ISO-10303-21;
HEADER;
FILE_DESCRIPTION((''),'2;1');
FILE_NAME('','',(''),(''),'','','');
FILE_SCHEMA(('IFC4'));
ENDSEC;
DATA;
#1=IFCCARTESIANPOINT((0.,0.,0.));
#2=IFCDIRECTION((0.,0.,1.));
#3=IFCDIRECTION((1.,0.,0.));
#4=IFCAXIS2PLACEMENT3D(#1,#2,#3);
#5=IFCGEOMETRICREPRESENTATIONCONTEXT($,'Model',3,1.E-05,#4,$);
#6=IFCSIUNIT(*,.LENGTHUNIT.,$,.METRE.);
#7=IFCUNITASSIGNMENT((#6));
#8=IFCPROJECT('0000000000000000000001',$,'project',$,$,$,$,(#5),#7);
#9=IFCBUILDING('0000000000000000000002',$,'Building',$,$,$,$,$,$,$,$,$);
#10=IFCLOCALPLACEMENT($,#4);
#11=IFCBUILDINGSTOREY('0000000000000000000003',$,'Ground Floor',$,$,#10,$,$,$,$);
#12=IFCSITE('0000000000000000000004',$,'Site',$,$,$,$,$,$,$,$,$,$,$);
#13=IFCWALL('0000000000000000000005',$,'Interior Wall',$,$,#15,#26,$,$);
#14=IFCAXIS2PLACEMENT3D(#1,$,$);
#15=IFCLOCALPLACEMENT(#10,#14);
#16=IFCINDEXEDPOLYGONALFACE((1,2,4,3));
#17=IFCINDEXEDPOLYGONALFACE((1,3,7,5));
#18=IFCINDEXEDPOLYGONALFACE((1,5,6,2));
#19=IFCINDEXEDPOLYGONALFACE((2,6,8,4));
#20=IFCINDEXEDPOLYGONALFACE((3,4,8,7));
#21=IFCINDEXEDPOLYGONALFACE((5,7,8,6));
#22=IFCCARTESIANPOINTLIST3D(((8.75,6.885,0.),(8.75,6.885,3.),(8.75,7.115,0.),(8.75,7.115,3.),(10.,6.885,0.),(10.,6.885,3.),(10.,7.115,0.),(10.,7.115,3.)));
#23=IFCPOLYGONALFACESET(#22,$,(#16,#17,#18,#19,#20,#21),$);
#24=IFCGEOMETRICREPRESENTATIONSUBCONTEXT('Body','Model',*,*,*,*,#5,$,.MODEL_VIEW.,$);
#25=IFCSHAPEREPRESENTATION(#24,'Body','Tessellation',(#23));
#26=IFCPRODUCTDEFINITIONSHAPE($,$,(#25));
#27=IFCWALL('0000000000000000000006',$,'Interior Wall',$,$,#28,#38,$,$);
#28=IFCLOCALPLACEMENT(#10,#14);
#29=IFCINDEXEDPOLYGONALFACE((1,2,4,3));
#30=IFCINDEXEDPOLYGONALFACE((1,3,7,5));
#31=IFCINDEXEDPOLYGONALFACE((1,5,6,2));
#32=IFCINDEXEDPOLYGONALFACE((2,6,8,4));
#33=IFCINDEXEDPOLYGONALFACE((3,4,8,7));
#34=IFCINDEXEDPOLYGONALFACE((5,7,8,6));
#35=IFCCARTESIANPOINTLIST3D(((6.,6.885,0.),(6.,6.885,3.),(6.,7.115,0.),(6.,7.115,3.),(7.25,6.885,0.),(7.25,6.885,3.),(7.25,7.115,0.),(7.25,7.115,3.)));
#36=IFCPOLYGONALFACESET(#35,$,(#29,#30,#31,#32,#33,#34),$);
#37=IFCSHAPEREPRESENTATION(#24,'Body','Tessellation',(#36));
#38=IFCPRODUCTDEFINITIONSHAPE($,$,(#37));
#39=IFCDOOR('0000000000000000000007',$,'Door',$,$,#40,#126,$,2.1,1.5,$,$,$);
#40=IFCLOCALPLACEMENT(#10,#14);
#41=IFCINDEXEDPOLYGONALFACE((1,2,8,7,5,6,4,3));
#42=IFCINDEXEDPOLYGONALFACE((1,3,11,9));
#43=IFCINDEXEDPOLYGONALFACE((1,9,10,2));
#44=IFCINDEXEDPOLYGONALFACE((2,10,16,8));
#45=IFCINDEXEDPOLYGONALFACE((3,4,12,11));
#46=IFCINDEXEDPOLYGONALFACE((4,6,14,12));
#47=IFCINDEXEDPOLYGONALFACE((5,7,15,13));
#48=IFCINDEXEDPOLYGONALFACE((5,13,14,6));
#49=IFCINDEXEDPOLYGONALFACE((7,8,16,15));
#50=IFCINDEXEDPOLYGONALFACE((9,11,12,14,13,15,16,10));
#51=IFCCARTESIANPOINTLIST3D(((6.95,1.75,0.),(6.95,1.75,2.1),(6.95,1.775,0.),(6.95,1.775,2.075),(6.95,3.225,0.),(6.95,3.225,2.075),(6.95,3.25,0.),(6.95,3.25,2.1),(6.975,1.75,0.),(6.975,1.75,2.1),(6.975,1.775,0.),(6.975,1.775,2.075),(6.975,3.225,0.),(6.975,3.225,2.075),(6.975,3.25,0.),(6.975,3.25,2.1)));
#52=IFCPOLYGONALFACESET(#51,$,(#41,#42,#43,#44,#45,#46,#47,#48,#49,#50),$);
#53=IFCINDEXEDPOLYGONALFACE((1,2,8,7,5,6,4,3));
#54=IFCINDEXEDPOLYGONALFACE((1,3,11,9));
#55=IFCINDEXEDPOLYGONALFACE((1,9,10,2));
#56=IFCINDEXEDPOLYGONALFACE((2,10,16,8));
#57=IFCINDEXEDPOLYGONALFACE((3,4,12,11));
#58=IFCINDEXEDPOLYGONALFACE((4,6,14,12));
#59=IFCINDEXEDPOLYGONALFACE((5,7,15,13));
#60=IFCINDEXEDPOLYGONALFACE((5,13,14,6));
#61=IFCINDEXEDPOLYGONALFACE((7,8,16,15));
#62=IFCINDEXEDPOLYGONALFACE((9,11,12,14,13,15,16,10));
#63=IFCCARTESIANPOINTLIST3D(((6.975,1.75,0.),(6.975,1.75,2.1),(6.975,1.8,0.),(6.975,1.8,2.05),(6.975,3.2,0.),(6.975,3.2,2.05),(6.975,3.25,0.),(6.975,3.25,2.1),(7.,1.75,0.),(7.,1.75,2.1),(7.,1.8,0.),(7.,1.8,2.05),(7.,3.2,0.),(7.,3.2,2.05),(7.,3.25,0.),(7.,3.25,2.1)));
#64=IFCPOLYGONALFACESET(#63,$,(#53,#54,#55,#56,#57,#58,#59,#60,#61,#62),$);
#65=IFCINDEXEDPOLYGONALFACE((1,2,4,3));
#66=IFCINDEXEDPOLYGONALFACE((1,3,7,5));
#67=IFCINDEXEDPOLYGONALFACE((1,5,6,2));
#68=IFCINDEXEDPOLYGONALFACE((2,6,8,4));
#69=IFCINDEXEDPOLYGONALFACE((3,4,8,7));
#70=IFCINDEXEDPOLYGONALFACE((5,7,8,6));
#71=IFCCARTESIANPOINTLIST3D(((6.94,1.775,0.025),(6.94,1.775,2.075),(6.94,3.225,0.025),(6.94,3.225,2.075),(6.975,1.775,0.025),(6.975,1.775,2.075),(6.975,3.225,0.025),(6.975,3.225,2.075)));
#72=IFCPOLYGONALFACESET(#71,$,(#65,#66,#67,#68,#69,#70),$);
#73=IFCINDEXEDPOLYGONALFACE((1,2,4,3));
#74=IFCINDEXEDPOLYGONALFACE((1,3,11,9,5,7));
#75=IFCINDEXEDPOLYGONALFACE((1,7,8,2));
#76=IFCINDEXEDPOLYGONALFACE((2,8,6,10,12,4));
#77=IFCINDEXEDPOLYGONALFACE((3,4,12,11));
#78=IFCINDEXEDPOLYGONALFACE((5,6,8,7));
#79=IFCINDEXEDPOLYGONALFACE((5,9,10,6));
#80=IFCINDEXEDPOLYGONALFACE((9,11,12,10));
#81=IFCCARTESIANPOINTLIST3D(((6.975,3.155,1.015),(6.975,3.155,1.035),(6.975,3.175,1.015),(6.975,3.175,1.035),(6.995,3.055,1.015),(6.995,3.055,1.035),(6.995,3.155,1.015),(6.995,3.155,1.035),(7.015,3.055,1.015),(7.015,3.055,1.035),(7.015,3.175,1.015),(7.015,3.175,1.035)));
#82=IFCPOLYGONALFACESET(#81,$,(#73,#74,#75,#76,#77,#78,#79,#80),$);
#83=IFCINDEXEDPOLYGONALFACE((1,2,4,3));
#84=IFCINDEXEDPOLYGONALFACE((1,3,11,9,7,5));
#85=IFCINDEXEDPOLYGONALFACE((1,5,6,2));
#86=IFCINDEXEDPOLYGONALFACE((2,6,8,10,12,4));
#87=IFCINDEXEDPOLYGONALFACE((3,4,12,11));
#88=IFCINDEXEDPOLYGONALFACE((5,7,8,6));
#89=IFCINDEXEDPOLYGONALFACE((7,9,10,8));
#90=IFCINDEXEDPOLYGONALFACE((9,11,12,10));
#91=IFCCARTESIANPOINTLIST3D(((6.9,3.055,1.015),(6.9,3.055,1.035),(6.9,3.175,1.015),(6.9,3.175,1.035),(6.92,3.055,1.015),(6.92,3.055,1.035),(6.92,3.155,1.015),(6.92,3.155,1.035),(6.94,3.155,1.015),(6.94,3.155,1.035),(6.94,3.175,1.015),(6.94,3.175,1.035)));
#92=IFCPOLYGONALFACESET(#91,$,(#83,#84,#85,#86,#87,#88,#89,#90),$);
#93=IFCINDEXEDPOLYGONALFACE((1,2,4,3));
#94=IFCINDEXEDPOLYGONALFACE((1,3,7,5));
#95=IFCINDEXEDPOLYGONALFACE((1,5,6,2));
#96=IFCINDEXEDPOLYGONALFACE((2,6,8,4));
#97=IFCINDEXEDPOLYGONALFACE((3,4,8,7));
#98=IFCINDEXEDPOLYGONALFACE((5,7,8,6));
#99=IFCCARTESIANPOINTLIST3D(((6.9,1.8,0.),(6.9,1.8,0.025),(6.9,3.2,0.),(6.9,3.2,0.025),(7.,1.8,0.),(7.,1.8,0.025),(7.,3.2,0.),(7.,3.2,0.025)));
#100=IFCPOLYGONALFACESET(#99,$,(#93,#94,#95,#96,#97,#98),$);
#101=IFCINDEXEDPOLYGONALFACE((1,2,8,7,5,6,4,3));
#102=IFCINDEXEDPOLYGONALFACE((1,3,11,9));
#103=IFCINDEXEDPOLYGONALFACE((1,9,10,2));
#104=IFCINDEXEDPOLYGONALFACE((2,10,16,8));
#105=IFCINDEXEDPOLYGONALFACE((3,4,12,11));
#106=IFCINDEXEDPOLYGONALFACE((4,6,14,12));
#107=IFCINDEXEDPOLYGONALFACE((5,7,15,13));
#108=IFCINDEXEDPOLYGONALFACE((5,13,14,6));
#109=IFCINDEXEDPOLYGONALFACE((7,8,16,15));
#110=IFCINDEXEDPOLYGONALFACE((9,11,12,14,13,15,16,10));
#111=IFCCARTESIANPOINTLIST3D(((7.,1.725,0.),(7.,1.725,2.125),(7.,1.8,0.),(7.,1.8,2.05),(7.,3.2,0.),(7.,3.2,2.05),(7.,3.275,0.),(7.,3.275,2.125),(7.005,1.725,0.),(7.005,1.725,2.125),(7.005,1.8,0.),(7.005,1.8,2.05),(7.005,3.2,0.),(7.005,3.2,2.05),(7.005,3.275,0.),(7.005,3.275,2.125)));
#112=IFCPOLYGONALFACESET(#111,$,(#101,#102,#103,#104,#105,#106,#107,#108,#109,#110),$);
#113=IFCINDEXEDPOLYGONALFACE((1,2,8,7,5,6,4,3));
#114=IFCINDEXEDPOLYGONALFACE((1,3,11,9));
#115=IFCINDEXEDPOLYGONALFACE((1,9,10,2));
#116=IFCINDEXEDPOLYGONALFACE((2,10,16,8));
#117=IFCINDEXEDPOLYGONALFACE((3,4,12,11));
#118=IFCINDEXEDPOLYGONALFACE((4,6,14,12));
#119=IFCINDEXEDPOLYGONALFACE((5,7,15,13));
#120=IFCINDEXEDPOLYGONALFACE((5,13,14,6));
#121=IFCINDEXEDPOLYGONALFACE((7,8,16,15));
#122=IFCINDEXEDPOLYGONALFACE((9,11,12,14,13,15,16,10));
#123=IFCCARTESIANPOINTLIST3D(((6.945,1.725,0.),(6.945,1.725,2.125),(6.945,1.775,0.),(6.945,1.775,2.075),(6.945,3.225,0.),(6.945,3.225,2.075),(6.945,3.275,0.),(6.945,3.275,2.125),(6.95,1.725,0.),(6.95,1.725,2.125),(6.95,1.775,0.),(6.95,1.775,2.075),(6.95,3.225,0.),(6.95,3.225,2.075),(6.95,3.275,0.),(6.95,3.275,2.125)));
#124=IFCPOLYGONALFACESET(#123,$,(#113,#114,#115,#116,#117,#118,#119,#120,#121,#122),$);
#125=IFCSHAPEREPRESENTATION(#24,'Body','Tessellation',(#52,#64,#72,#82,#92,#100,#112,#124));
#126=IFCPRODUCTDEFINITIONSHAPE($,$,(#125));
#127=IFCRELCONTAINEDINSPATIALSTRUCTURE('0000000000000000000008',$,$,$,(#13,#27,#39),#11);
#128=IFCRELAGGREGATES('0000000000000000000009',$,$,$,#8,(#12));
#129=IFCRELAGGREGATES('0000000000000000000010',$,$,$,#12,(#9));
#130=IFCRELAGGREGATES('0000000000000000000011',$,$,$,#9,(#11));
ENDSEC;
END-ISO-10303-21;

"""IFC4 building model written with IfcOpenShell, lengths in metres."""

from ifc_helpers import new_model, si_unit, frame, origin_with_axes, place, context, subcontext, project, spatial, line, indexed_curve, outline, extrude, element, save


model = new_model("IFC4")

# Units and contexts
model_context = context("Model", 3, precision=1e-05, world=origin_with_axes())
body_context = subcontext(model_context, "Body", "Model", "MODEL_VIEW")
ifc_project = project(units=[si_unit("LENGTHUNIT", "METRE")], contexts=[model_context])

# Site, building, storey
site = spatial("IfcSite", under=ifc_project, Name="Site")
building = spatial("IfcBuilding", under=site, Name="Building")
storey_placement = place(None, origin_with_axes())
storey = spatial("IfcBuildingStorey", under=building, at=storey_placement, Name="Ground Floor")

# Walls
for number, where, z_axis, x_axis, name in (
    (1, (10.0, 7.0, 0.0), (0.0, 0.0, 1.0), (-1.0, 0.0, 0.0), "Interior Wall"),
    (2, (7.25, 7.0, 0.0), (0.0, 0.0, 1.0), (-1.0, 0.0, 0.0), "Interior Wall"),
):
    element("IfcWall", number, at=place(storey_placement, frame(where, z_axis=z_axis, x_axis=x_axis)), inside=storey, Name=name, context=body_context, shape_type="SweptSolid", body=[
        extrude(outline(indexed_curve([(0.0, 0.0), (0.0, 0.23), (1.25, 0.23), (1.25, 0.0), (0.0, 0.0)], self_intersect=False)), frame((0.0, -0.115, 0.0), z_axis=(0.0, 0.0, 1.0), x_axis=(1.0, 0.0, 0.0)), (0.0, 0.0, 1.0), 3.0),
    ])

# Door
door_1_placement = place(storey_placement, frame((7.0, 1.75, 0.0), z_axis=(0.0, 0.0, 1.0), x_axis=(0.0, 1.0, 0.0)))
element("IfcDoor", 3, at=door_1_placement, inside=storey, Name="Door", OverallHeight=2.1, OverallWidth=1.5, context=body_context, shape_type="SweptSolid", body=[
    extrude(outline(indexed_curve([(0.0, 0.0), (0.0, 2.1), (1.5, 2.1), (1.5, 0.0), (1.475, 0.0), (1.475, 2.075), (0.025, 2.075), (0.025, 0.0)], segments=[line(1, 2, 3, 4, 5, 6, 7, 8, 1)])), frame((0.0, 0.025, 0.0), z_axis=(0.0, -1.0, 0.0), x_axis=(1.0, 0.0, 0.0)), (0.0, 0.0, -1.0), 0.025),
    extrude(outline(indexed_curve([(0.0, 0.0), (0.0, 2.1), (1.5, 2.1), (1.5, 0.0), (1.45, 0.0), (1.45, 2.05), (0.05, 2.05), (0.05, 0.0)], segments=[line(1, 2, 3, 4, 5, 6, 7, 8, 1)])), frame((0.0, 0.0, 0.0), z_axis=(0.0, -1.0, 0.0), x_axis=(1.0, 0.0, 0.0)), (0.0, 0.0, -1.0), 0.025),
    extrude(outline(indexed_curve([(0.0, 0.0), (1.45, 0.0), (1.45, 0.035), (0.0, 0.035)], segments=[line(1, 2, 3, 4, 1)])), frame((0.025, 0.025, 0.025), z_axis=(0.0, 0.0, 1.0), x_axis=(1.0, 0.0, 0.0)), (0.0, 0.0, 1.0), 2.05),
    extrude(outline(indexed_curve([(0.0, 0.0), (0.0, -0.04), (-0.12, -0.04), (-0.12, -0.02), (-0.02, -0.02), (-0.02, 0.0)], segments=[line(1, 2, 3, 4, 5, 6, 1)])), frame((1.425, 0.025, 1.015), z_axis=(0.0, 0.0, 1.0), x_axis=(1.0, 0.0, 0.0)), (0.0, 0.0, 1.0), 0.02),
    extrude(outline(indexed_curve([(0.0, 0.0), (0.0, 0.04), (-0.12, 0.04), (-0.12, 0.02), (-0.02, 0.02), (-0.02, 0.0)], segments=[line(1, 2, 3, 4, 5, 6, 1)])), frame((1.425, 0.06, 1.015), z_axis=(0.0, 0.0, 1.0), x_axis=(1.0, 0.0, 0.0)), (0.0, 0.0, 1.0), 0.02),
    extrude(outline(indexed_curve([(0.0, 0.0), (1.4, 0.0), (1.4, 0.1), (0.0, 0.1)], segments=[line(1, 2, 3, 4, 1)])), frame((0.05, 0.0, 0.0), z_axis=(0.0, 0.0, 1.0), x_axis=(1.0, 0.0, 0.0)), (0.0, 0.0, 1.0), 0.025),
    extrude(outline(indexed_curve([(0.0, 0.0), (0.0, 2.125), (1.55, 2.125), (1.55, 0.0), (1.475, 0.0), (1.475, 2.05), (0.075, 2.05), (0.075, 0.0)], segments=[line(1, 2, 3, 4, 5, 6, 7, 8, 1)])), frame((-0.025, -0.005, 0.0), z_axis=(0.0, -1.0, 0.0), x_axis=(1.0, 0.0, 0.0)), (0.0, 0.0, -1.0), 0.005),
    extrude(outline(indexed_curve([(0.0, 0.0), (0.0, 2.125), (1.55, 2.125), (1.55, 0.0), (1.5, 0.0), (1.5, 2.075), (0.05, 2.075), (0.05, 0.0)], segments=[line(1, 2, 3, 4, 5, 6, 7, 8, 1)])), frame((-0.025, 0.05, 0.0), z_axis=(0.0, -1.0, 0.0), x_axis=(1.0, 0.0, 0.0)), (0.0, 0.0, -1.0), 0.005),
])

save(model, "model.ifc")
